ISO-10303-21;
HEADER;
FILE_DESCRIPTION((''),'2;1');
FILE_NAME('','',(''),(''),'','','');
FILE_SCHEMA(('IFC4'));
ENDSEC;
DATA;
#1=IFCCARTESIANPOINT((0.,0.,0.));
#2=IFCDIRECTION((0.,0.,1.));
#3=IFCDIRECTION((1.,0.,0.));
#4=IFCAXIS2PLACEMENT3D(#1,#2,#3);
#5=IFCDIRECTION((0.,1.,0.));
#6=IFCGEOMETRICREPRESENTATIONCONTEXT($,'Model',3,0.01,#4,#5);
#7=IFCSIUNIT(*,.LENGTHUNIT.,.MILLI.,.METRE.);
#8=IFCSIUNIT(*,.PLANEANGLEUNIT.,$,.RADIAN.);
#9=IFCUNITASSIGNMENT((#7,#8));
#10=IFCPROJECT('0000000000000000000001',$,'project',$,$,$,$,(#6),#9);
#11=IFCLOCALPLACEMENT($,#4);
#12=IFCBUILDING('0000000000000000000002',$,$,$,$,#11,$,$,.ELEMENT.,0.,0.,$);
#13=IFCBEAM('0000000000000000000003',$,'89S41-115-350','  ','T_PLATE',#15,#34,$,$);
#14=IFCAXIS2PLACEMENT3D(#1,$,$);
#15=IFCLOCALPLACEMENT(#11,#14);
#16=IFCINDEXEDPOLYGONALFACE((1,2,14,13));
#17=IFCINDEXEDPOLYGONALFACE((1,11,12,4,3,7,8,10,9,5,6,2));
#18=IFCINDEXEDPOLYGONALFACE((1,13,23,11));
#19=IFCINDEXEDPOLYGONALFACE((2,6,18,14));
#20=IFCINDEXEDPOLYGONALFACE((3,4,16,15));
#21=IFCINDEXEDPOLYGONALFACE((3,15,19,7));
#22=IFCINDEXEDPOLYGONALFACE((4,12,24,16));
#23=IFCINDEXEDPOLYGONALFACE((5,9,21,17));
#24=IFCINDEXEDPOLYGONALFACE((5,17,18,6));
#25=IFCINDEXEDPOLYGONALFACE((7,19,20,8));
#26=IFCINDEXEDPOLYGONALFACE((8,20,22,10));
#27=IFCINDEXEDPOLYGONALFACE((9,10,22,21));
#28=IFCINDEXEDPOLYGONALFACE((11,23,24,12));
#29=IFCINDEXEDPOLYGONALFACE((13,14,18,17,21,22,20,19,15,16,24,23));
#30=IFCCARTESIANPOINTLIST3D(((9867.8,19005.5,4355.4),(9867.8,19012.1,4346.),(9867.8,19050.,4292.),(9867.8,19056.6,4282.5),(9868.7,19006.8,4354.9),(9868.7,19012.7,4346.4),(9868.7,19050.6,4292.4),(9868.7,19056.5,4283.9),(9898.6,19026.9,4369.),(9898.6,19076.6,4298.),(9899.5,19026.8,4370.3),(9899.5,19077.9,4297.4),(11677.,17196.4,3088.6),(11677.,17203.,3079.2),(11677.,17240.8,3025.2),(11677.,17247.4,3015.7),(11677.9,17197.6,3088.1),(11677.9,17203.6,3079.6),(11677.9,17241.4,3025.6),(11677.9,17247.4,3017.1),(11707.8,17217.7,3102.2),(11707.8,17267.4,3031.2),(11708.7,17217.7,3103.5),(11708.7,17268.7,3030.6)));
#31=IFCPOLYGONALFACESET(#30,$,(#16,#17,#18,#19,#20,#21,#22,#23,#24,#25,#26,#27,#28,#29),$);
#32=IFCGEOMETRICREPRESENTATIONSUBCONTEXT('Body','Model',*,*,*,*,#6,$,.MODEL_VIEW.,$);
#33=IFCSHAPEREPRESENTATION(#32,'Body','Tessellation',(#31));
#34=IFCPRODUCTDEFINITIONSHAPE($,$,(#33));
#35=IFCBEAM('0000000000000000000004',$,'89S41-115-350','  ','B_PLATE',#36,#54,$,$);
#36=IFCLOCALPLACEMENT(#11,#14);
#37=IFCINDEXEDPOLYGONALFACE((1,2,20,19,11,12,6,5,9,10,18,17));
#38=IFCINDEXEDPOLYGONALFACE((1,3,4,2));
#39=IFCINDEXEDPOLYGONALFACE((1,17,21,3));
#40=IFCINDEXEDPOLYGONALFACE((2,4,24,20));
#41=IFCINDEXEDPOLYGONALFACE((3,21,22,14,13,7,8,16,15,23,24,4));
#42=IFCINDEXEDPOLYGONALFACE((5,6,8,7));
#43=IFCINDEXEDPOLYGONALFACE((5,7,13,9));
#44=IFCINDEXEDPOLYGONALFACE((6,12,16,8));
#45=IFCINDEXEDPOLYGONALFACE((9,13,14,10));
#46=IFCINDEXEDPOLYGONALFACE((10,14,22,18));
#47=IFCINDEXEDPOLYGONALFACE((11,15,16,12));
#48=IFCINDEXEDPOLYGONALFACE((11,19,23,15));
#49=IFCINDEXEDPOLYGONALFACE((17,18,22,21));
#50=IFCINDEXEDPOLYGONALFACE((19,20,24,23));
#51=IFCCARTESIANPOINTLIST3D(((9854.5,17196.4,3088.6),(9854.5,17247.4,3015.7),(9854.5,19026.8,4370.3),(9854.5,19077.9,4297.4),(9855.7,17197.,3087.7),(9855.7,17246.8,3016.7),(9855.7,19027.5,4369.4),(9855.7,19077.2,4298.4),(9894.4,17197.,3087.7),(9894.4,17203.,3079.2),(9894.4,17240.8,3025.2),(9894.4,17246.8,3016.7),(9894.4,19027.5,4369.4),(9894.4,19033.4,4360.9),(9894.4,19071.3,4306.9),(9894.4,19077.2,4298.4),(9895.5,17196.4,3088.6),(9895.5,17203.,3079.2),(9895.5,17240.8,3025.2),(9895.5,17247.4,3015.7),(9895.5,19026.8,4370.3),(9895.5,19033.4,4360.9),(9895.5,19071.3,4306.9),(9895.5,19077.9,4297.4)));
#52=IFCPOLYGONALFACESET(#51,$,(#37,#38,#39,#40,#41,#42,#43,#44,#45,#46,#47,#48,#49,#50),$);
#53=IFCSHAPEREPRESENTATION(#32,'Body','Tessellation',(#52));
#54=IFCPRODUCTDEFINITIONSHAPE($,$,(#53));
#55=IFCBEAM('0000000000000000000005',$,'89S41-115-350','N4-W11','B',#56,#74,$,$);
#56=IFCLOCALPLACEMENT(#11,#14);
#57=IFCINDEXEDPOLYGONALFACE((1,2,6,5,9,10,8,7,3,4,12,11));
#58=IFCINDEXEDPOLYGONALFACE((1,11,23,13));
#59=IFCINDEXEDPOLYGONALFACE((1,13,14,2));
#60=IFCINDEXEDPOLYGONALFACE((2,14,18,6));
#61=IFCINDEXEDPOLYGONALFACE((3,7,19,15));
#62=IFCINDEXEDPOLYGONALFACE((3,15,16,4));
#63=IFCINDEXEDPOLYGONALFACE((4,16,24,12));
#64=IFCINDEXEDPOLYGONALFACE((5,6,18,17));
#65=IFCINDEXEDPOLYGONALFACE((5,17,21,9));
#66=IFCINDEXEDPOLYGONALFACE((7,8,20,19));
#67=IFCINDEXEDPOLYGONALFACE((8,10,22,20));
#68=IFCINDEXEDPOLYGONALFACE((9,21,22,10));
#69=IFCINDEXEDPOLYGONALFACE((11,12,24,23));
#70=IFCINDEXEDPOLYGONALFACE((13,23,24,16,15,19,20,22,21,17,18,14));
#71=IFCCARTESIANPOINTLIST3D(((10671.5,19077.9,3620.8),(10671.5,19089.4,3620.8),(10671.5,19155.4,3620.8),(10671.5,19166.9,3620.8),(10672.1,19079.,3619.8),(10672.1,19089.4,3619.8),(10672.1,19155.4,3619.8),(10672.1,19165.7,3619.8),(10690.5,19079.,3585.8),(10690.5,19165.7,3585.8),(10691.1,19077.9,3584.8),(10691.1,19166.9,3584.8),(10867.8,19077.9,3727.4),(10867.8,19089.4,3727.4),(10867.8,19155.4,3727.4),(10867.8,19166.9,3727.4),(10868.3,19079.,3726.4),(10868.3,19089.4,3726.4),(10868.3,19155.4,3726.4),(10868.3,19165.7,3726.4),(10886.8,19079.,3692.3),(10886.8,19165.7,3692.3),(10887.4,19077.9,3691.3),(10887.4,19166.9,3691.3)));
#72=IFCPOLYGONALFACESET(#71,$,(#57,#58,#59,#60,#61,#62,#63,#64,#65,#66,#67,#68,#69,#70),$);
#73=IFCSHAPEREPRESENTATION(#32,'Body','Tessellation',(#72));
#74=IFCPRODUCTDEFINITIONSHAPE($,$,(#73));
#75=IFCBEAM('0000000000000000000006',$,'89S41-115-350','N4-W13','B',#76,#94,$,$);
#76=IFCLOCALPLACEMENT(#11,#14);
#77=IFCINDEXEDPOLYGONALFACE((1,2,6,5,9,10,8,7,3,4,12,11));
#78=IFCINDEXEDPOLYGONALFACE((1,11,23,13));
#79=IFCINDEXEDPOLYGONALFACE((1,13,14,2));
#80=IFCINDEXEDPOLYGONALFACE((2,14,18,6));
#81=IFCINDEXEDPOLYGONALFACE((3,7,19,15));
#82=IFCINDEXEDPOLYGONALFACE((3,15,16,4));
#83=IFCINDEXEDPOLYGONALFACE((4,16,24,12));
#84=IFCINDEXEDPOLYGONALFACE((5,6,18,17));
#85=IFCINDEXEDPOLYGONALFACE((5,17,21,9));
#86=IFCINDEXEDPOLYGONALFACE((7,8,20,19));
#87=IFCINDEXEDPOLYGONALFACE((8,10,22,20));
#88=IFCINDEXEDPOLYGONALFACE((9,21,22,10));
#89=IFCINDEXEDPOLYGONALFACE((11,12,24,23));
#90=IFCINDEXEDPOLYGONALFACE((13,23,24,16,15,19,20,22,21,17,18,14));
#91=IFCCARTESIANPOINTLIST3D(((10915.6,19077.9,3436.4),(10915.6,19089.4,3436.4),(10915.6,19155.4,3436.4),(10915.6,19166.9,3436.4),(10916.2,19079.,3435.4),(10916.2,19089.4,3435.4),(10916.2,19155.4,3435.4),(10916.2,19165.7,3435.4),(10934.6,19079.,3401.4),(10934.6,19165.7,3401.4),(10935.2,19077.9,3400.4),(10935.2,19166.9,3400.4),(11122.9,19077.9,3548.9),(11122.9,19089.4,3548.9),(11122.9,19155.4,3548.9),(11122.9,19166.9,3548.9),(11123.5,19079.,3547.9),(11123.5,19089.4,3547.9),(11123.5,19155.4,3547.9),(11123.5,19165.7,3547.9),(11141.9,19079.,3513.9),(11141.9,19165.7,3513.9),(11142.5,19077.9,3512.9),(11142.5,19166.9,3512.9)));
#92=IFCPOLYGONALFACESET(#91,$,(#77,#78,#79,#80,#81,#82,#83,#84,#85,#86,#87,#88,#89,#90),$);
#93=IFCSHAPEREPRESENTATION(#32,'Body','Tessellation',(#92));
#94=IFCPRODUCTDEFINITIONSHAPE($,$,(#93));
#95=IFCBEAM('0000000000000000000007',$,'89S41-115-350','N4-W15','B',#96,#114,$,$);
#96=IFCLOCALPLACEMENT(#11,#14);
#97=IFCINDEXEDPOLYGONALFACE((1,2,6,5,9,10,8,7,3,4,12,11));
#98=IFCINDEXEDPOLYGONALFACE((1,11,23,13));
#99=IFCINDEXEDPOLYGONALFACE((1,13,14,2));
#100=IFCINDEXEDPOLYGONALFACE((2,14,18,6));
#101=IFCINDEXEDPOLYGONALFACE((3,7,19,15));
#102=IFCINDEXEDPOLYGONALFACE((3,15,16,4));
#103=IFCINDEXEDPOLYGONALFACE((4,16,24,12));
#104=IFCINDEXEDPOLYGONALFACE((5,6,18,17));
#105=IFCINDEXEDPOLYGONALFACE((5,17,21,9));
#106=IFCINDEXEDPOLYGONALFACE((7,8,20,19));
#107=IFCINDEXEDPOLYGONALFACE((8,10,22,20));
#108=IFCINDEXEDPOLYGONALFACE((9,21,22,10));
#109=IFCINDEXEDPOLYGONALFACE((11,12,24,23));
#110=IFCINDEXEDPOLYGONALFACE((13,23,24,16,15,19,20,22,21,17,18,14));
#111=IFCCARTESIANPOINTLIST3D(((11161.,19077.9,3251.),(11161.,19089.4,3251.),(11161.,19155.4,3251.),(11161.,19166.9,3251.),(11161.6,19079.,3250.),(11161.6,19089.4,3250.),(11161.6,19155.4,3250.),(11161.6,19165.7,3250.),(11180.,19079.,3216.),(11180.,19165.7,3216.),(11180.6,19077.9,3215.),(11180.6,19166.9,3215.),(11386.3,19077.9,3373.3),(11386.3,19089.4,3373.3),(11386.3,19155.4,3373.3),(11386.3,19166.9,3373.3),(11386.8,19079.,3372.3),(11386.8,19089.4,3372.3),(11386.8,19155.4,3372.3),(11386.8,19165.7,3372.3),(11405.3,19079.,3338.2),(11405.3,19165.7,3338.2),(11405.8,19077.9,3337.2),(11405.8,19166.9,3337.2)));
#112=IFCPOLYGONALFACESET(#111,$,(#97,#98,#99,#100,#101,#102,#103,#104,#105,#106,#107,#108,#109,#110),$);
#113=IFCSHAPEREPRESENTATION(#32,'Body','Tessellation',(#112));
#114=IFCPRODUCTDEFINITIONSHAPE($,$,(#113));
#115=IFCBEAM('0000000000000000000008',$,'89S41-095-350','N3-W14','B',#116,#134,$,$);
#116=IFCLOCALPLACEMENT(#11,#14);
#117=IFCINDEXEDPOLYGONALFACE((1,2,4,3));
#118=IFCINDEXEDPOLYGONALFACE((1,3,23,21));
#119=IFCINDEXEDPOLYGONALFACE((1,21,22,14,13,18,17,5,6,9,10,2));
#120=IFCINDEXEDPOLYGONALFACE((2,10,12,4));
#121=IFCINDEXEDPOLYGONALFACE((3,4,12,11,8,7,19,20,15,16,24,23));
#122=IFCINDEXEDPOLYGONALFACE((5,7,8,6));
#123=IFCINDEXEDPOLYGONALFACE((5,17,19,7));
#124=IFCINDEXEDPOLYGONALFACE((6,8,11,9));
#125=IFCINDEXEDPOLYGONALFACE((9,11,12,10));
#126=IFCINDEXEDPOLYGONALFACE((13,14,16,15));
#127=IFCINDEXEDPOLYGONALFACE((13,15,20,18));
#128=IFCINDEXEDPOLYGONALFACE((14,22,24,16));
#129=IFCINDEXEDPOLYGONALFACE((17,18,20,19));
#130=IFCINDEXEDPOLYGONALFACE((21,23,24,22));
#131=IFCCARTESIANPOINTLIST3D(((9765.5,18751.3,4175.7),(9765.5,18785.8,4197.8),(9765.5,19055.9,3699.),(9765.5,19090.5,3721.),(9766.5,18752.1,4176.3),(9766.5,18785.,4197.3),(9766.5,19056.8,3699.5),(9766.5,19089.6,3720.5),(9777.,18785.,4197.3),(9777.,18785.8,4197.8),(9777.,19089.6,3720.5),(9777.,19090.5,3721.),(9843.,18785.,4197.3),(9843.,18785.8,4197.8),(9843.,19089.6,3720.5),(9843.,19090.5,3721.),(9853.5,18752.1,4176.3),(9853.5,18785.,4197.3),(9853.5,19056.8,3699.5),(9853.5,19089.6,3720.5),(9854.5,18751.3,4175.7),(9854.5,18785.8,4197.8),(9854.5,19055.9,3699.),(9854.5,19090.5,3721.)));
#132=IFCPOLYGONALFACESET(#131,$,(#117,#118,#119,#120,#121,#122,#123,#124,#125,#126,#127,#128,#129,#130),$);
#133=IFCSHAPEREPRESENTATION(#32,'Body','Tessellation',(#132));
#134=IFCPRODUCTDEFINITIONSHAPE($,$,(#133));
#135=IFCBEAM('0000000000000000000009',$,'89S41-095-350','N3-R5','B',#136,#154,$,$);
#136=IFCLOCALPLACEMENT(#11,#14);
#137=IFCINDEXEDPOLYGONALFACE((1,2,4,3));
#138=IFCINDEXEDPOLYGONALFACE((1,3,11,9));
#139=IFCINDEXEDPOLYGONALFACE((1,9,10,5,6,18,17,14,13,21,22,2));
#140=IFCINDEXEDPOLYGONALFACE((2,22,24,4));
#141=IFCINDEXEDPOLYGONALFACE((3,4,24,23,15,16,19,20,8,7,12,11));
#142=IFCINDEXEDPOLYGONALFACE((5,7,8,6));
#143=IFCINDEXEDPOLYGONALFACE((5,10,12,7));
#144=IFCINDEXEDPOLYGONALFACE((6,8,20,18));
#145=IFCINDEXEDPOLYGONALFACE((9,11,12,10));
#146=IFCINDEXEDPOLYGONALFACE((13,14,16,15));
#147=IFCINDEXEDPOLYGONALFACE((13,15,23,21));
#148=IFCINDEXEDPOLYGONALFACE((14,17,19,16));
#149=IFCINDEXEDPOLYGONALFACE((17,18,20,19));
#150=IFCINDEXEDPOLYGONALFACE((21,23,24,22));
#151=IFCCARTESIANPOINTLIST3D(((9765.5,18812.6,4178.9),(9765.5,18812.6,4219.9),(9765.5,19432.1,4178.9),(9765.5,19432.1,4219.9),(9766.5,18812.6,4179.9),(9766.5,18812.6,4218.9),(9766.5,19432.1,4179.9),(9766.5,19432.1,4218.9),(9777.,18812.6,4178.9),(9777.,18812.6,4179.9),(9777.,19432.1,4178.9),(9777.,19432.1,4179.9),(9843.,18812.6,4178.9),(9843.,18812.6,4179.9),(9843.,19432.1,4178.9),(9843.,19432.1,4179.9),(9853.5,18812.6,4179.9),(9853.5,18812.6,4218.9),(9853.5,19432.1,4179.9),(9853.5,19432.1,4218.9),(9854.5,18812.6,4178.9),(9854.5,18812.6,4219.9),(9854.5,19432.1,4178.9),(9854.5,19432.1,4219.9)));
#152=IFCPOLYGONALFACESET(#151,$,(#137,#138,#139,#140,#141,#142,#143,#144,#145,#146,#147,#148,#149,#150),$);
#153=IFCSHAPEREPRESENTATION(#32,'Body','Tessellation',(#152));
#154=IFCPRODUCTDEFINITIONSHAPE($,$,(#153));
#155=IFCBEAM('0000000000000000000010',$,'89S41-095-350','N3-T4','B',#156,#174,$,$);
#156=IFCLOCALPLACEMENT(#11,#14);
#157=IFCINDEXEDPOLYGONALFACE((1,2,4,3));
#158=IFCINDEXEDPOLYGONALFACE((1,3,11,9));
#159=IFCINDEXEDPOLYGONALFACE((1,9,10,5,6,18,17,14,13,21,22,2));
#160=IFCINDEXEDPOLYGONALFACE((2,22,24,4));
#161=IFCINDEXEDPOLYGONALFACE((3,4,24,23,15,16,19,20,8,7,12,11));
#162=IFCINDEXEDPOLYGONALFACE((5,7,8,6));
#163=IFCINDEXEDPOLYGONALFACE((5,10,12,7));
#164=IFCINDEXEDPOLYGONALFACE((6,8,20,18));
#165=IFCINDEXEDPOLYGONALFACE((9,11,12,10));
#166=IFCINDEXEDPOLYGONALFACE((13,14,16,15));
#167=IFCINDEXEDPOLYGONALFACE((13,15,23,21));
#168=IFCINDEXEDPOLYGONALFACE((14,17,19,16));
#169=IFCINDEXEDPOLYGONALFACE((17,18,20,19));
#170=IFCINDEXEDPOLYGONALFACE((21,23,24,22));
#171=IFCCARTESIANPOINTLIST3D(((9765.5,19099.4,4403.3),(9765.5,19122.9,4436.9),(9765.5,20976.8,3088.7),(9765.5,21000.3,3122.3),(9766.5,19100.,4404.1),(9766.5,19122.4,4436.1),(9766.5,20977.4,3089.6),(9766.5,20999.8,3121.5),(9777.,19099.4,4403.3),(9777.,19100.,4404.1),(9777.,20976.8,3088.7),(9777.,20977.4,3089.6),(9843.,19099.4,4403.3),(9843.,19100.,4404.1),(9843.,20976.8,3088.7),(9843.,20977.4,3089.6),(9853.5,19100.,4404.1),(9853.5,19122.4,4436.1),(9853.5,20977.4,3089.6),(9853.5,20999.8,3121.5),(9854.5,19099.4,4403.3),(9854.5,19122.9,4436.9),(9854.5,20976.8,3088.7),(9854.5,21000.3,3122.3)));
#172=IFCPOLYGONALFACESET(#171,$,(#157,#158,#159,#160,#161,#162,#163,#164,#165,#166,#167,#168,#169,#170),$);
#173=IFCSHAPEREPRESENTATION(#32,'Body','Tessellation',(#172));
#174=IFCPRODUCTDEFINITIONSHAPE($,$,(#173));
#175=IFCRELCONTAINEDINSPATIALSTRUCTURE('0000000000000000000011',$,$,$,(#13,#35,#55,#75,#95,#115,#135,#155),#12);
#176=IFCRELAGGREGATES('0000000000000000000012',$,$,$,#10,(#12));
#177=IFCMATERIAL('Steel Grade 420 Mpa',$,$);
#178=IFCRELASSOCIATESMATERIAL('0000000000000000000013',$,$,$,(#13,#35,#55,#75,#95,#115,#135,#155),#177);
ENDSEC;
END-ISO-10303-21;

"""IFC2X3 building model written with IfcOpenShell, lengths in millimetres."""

from ifc_helpers import new_model, si_unit, direction, frame, origin, origin_with_axes, origin_2d_with_axis, place, context, subcontext, project, spatial, c_section, extrude, source, transform, mapped, material, element, save


model = new_model("IFC2X3")

# Units and contexts
model_context = context("Model", 3, precision=0.01, world=origin_with_axes(), true_north=direction((0.0, 1.0, 0.0)))
body_context = subcontext(model_context, "Body", "Model", "MODEL_VIEW")
ifc_project = project(units=[si_unit("LENGTHUNIT", "METRE", prefix="MILLI"), si_unit("PLANEANGLEUNIT", "RADIAN")], contexts=[model_context])

# Building
building_placement = place(None, origin_with_axes())
building = spatial("IfcBuilding", under=ifc_project, at=building_placement, CompositionType="ELEMENT", ElevationOfRefHeight=0.0, ElevationOfTerrain=0.0)

# Shared definitions
ifc_material = material(Name="Steel Grade 420 Mpa")

# Beams
shared_shape_1 = source(origin(), body_context, "Body", "SweptSolid", [
    extrude(c_section(Depth=89.0, Width=41.0, WallThickness=1.1, Girth=11.5, at=origin_2d_with_axis()), origin_with_axes(), (0.0, 0.0, 1.0), 2855.0),
])
beam_1_placement = place(None, frame((9883.7, 19041.7, 4326.4), z_axis=(0.633687, -0.633687, -0.443713), x_axis=(-0.773589, -0.519086, -0.363468)))
element("IfcBeam", 1, at=beam_1_placement, inside=building, material=ifc_material, Name="89S41-115-350", Description="  ", ObjectType="T_PLATE", context=body_context, shape_type="MappedRepresentation", body=[
    mapped(shared_shape_1, transform((0.0, 0.0, 0.0), scale=1.0)),
])
shared_shape_2 = source(origin(), body_context, "Body", "SweptSolid", [
    extrude(c_section(Depth=89.0, Width=41.0, WallThickness=1.1, Girth=11.5, at=origin_2d_with_axis()), origin_with_axes(), (0.0, 0.0, 1.0), 2234.6),
])
beam_2_placement = place(None, frame((9875.0, 19052.3, 4333.9), z_axis=(0.0, -0.819152, -0.573576), x_axis=(1.0, 0.0, 0.0)))
element("IfcBeam", 2, at=beam_2_placement, inside=building, material=ifc_material, Name="89S41-115-350", Description="  ", ObjectType="B_PLATE", context=body_context, shape_type="MappedRepresentation", body=[
    mapped(shared_shape_2, transform((0.0, 0.0, 0.0), scale=1.0)),
])
shared_shape_3 = source(origin(), body_context, "Body", "SweptSolid", [
    extrude(c_section(Depth=89.0, Width=41.0, WallThickness=1.1, Girth=11.5, at=origin_2d_with_axis()), origin_with_axes(), (0.0, 0.0, 1.0), 223.3),
])
beam_3_placement = place(None, frame((10681.3, 19122.4, 3602.8), z_axis=(0.878886, 0.0, 0.477032), x_axis=(-0.477032, 0.0, 0.878886)))
element("IfcBeam", 3, at=beam_3_placement, inside=building, material=ifc_material, Name="89S41-115-350", Description="N4-W11", ObjectType="B", context=body_context, shape_type="MappedRepresentation", body=[
    mapped(shared_shape_3, transform((0.0, 0.0, 0.0), scale=1.0)),
])
shared_shape_4 = source(origin(), body_context, "Body", "SweptSolid", [
    extrude(c_section(Depth=89.0, Width=41.0, WallThickness=1.1, Girth=11.5, at=origin_2d_with_axis()), origin_with_axes(), (0.0, 0.0, 1.0), 235.9),
])
beam_4_placement = place(None, frame((10925.4, 19122.4, 3418.4), z_axis=(0.878886, 0.0, 0.477032), x_axis=(-0.477032, 0.0, 0.878886)))
element("IfcBeam", 4, at=beam_4_placement, inside=building, material=ifc_material, Name="89S41-115-350", Description="N4-W13", ObjectType="B", context=body_context, shape_type="MappedRepresentation", body=[
    mapped(shared_shape_4, transform((0.0, 0.0, 0.0), scale=1.0)),
])
shared_shape_5 = source(origin(), body_context, "Body", "SweptSolid", [
    extrude(c_section(Depth=89.0, Width=41.0, WallThickness=1.1, Girth=11.5, at=origin_2d_with_axis()), origin_with_axes(), (0.0, 0.0, 1.0), 256.3),
])
beam_5_placement = place(None, frame((11170.8, 19122.4, 3233.0), z_axis=(0.878886, 0.0, 0.477032), x_axis=(-0.477032, 0.0, 0.878886)))
element("IfcBeam", 5, at=beam_5_placement, inside=building, material=ifc_material, Name="89S41-115-350", Description="N4-W15", ObjectType="B", context=body_context, shape_type="MappedRepresentation", body=[
    mapped(shared_shape_5, transform((0.0, 0.0, 0.0), scale=1.0)),
])
shared_shape_6 = source(origin(), body_context, "Body", "SweptSolid", [
    extrude(c_section(Depth=89.0, Width=41.0, WallThickness=1.0, Girth=11.5, at=origin_2d_with_axis()), origin_with_axes(), (0.0, 0.0, 1.0), 565.8),
])
beam_6_placement = place(None, frame((9810.0, 19073.2, 3710.0), z_axis=(0.0, -0.538498, 0.842627), x_axis=(0.0, 0.842627, 0.538498)))
element("IfcBeam", 6, at=beam_6_placement, inside=building, material=ifc_material, Name="89S41-095-350", Description="N3-W14", ObjectType="B", context=body_context, shape_type="MappedRepresentation", body=[
    mapped(shared_shape_6, transform((0.0, 0.0, 0.0), scale=1.0)),
])
shared_shape_7 = source(origin(), body_context, "Body", "SweptSolid", [
    extrude(c_section(Depth=89.0, Width=41.0, WallThickness=1.0, Girth=11.5, at=origin_2d_with_axis()), origin_with_axes(), (0.0, 0.0, 1.0), 619.5),
])
beam_7_placement = place(None, frame((9810.0, 18812.6, 4199.4), z_axis=(0.0, 1.0, 0.0), x_axis=(0.0, 0.0, -1.0)))
element("IfcBeam", 7, at=beam_7_placement, inside=building, material=ifc_material, Name="89S41-095-350", Description="N3-R5", ObjectType="B", context=body_context, shape_type="MappedRepresentation", body=[
    mapped(shared_shape_7, transform((0.0, 0.0, 0.0), scale=1.0)),
])
shared_shape_8 = source(origin(), body_context, "Body", "SweptSolid", [
    extrude(c_section(Depth=89.0, Width=41.0, WallThickness=1.0, Girth=11.5, at=origin_2d_with_axis()), origin_with_axes(), (0.0, 0.0, 1.0), 2291.9),
])
beam_8_placement = place(None, frame((9810.0, 19111.2, 4420.1), z_axis=(0.0, 0.819152, -0.573576), x_axis=(0.0, -0.573576, -0.819152)))
element("IfcBeam", 8, at=beam_8_placement, inside=building, material=ifc_material, Name="89S41-095-350", Description="N3-T4", ObjectType="B", context=body_context, shape_type="MappedRepresentation", body=[
    mapped(shared_shape_8, transform((0.0, 0.0, 0.0), scale=1.0)),
])

save(model, "model.ifc")
